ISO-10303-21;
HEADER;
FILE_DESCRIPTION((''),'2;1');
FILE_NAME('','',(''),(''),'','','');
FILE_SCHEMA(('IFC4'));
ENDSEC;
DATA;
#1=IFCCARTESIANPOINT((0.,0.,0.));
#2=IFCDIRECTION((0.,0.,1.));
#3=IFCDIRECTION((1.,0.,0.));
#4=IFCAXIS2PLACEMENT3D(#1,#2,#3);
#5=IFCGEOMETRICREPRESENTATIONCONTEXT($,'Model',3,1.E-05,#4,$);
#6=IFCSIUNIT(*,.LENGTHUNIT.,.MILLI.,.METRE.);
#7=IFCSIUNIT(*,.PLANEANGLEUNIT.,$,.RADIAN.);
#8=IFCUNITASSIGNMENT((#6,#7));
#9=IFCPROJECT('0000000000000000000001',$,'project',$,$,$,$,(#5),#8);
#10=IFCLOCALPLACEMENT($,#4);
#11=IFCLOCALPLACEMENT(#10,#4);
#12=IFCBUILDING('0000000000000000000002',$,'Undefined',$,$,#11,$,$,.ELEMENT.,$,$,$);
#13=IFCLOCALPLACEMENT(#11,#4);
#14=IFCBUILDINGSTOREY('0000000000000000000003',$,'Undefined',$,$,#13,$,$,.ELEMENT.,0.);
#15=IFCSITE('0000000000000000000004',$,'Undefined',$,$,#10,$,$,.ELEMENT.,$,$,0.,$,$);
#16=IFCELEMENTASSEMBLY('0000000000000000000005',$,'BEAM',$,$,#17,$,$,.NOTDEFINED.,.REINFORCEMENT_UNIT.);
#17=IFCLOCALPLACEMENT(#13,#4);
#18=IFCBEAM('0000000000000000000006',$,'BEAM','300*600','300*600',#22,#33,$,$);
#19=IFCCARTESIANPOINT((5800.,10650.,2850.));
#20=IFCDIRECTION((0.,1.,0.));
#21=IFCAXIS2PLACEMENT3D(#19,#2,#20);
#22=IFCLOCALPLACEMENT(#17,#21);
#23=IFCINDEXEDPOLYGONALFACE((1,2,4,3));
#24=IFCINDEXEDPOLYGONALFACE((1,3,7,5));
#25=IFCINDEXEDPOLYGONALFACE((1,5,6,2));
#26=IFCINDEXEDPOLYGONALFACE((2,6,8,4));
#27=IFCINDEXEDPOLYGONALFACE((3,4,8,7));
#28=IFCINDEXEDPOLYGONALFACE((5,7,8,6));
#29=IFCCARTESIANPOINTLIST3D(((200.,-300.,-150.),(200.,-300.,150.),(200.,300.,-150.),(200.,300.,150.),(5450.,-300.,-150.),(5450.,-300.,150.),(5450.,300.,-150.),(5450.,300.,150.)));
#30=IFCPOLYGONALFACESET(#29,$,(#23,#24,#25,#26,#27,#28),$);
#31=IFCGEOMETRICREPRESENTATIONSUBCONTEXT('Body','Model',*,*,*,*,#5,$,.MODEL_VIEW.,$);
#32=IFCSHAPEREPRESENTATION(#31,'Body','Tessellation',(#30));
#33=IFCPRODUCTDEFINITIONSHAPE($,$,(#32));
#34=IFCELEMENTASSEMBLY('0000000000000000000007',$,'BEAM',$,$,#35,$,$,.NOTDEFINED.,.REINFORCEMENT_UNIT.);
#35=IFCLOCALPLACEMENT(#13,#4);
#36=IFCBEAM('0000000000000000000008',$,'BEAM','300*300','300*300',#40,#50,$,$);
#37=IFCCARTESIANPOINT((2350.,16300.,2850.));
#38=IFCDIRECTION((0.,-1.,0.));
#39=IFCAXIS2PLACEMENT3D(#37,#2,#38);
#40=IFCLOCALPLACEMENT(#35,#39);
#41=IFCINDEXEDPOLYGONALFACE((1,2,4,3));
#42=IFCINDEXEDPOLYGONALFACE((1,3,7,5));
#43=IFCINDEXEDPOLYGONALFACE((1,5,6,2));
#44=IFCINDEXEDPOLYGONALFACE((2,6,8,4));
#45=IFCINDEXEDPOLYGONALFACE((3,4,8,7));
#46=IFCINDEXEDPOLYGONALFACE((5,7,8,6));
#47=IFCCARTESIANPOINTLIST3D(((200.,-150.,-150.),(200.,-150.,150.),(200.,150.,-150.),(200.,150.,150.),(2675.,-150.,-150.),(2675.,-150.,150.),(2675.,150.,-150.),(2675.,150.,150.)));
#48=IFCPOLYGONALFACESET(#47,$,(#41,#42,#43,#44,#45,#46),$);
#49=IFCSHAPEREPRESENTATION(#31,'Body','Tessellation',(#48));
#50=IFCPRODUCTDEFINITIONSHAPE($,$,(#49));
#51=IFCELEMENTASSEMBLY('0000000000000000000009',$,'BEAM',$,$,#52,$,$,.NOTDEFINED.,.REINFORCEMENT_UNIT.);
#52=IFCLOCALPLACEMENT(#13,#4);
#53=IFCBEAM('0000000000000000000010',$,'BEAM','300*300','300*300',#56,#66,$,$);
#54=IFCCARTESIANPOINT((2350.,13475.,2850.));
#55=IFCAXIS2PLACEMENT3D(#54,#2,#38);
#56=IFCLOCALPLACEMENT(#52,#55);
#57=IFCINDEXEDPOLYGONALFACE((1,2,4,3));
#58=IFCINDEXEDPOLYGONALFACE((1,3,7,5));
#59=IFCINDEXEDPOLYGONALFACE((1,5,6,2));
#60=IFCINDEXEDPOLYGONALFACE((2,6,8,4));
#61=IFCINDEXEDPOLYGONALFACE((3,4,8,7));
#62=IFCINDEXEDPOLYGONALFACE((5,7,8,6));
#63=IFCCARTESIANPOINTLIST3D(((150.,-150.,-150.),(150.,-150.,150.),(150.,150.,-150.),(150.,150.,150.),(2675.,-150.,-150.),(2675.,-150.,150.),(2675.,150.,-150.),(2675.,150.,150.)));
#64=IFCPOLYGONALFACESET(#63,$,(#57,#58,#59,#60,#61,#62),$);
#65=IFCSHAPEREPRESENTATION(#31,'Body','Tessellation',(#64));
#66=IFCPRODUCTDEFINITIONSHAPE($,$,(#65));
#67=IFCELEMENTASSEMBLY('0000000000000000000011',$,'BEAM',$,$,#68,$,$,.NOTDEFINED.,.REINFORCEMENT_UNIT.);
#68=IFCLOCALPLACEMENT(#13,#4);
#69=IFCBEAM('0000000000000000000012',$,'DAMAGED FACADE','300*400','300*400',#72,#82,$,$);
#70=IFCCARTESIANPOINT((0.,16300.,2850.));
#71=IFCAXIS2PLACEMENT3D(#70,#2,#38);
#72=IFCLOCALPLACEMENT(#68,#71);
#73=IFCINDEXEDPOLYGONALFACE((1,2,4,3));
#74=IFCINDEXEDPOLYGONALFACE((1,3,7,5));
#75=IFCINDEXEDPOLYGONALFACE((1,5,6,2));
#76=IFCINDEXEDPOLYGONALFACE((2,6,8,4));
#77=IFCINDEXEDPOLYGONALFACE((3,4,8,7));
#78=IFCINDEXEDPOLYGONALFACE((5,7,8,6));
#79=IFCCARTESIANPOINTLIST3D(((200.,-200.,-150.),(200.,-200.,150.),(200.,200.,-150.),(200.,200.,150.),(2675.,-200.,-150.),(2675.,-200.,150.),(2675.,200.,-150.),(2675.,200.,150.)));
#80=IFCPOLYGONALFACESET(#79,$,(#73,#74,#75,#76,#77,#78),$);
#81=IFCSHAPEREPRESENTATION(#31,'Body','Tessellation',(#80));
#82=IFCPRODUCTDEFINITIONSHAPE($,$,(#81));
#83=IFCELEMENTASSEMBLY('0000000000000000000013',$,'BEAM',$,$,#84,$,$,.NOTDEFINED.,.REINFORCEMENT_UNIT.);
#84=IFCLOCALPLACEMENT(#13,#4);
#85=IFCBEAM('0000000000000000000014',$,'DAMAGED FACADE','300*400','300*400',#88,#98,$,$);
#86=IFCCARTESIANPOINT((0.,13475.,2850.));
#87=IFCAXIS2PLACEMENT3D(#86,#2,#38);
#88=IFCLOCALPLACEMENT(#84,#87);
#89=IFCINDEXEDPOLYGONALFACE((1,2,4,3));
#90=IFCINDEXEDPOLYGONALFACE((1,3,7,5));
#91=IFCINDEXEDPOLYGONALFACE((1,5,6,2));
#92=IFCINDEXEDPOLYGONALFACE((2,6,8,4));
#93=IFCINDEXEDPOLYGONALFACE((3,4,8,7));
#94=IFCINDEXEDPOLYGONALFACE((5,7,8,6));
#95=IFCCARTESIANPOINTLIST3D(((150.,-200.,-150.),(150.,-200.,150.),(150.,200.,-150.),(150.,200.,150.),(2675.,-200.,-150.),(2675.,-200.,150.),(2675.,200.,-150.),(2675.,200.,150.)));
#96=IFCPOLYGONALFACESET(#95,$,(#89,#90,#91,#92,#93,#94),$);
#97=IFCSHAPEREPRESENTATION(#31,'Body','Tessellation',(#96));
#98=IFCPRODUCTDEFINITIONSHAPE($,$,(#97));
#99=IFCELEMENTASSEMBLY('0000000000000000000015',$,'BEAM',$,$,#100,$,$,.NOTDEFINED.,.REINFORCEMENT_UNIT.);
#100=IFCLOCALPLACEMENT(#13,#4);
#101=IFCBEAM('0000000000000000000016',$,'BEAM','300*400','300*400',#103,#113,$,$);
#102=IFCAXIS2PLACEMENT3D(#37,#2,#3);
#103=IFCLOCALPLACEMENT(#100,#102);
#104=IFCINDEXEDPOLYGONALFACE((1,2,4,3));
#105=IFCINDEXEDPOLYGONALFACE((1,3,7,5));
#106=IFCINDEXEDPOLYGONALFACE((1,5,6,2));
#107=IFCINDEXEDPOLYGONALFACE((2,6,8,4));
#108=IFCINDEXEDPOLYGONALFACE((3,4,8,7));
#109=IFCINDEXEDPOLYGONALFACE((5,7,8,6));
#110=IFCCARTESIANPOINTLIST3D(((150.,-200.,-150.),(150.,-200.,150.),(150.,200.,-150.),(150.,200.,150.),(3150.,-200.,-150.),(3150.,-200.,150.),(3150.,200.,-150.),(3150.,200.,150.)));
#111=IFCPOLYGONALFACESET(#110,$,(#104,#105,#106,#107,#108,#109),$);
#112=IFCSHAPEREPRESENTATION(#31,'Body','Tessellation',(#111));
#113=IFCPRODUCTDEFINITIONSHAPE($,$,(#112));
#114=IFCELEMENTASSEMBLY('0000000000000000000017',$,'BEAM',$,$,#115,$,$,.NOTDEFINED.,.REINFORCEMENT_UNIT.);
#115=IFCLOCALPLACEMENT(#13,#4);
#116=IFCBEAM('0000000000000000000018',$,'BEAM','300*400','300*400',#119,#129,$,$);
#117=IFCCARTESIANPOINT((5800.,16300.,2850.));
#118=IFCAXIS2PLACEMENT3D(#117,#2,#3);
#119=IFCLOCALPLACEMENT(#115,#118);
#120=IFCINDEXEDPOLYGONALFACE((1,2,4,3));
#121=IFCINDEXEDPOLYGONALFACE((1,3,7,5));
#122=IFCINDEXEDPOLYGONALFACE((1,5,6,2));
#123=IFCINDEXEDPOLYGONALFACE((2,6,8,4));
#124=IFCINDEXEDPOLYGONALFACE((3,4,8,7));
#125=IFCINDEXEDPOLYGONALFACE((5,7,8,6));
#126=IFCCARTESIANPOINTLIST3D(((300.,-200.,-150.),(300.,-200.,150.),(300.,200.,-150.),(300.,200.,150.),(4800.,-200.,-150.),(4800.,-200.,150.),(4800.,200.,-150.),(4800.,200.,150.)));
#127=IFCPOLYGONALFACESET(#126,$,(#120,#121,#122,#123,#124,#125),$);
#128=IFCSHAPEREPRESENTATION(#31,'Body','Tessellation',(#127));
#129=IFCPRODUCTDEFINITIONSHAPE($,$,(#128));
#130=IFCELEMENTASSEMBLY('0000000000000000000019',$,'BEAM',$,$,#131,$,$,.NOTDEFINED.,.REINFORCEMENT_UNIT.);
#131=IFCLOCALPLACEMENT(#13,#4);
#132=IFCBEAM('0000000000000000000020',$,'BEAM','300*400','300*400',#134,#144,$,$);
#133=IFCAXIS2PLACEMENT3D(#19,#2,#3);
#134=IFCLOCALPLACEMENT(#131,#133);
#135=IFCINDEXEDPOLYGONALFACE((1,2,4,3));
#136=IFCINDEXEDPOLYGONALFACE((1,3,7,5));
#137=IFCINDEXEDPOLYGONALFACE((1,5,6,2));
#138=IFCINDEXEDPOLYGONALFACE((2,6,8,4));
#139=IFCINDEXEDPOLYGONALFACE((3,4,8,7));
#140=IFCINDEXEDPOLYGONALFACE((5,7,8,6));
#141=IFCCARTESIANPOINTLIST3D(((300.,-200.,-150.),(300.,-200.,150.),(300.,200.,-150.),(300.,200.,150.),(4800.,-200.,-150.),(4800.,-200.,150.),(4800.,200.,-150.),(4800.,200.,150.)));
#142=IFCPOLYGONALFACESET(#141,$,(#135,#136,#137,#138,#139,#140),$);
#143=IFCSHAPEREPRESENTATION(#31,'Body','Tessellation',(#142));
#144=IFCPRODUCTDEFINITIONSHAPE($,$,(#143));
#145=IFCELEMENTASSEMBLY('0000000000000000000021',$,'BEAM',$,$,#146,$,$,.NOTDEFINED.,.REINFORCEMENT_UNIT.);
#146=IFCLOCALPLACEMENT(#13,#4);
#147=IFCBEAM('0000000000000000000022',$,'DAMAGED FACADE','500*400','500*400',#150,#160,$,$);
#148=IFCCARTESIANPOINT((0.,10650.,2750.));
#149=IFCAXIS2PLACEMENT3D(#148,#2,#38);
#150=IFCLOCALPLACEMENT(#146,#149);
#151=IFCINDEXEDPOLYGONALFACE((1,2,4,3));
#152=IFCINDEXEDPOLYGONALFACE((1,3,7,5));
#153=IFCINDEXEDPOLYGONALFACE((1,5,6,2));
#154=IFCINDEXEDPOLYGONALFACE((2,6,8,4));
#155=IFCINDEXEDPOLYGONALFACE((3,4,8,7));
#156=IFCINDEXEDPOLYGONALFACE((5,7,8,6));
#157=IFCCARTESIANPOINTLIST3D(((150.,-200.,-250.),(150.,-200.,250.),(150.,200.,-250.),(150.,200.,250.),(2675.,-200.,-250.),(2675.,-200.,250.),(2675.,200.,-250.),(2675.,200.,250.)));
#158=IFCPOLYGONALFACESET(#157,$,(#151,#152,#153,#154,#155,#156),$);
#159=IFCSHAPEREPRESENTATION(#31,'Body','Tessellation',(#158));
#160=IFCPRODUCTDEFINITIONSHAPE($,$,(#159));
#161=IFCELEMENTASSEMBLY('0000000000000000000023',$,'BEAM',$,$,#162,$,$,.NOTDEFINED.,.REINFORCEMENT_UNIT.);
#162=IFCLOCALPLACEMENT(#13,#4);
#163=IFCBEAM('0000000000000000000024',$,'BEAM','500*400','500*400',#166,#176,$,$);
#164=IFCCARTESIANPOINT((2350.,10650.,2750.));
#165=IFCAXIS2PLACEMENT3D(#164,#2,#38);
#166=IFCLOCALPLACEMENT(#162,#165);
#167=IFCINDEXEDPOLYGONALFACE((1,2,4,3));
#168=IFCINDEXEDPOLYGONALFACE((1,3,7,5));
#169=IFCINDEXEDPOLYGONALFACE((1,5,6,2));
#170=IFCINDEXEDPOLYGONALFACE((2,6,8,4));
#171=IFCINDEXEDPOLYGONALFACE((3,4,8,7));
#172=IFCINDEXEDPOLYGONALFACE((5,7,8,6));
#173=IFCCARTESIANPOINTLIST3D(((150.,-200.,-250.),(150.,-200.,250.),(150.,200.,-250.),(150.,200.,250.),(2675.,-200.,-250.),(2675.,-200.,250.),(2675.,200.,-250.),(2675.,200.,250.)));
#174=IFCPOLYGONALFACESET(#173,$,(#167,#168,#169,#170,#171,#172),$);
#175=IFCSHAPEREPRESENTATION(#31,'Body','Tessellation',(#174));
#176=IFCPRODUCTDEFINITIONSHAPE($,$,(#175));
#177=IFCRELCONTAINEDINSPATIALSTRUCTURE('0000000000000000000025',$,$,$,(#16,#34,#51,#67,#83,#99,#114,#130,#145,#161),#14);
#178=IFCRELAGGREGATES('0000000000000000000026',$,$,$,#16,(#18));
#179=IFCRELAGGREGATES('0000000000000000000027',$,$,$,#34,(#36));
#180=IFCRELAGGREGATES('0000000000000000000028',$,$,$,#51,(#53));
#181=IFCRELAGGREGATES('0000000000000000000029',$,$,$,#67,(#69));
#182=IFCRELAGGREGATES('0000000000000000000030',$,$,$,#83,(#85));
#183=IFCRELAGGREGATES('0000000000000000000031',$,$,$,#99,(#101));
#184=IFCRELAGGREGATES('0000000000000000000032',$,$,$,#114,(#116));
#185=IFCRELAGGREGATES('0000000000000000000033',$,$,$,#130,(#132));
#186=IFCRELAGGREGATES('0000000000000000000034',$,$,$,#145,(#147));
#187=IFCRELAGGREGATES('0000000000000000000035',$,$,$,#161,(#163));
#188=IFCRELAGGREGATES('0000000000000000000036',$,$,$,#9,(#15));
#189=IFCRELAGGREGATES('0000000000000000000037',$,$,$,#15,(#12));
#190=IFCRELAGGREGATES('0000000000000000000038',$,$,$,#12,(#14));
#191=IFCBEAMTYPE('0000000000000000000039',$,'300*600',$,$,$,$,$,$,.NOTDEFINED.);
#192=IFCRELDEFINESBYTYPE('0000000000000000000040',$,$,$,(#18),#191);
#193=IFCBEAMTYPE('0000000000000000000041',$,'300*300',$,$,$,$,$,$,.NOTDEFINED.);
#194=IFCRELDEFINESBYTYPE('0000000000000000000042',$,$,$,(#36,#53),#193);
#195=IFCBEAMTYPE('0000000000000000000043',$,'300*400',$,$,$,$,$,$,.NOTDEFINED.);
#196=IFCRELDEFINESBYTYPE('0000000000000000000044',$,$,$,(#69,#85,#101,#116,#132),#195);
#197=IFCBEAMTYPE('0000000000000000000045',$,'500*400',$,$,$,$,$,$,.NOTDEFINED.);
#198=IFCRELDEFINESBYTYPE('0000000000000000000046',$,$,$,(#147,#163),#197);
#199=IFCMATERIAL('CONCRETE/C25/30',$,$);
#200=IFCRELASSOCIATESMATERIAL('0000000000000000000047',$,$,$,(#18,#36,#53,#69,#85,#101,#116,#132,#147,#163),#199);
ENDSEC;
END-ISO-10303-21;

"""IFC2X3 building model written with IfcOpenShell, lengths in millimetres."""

from ifc_helpers import new_model, si_unit, frame, origin_with_axes, origin_2d_with_axis, place, context, subcontext, project, spatial, rectangle, extrude, material, type_object, element, aggregate, save


model = new_model("IFC2X3")

# Units and contexts
model_context = context("Model", 3, precision=1e-05, world=origin_with_axes())
body_context = subcontext(model_context, "Body", "Model", "MODEL_VIEW")
ifc_project = project(units=[si_unit("LENGTHUNIT", "METRE", prefix="MILLI"), si_unit("PLANEANGLEUNIT", "RADIAN")], contexts=[model_context])

# Site, building, storey
site_placement = place(None, origin_with_axes())
site = spatial("IfcSite", under=ifc_project, at=site_placement, Name="Undefined", CompositionType="ELEMENT", RefElevation=0.0)
building_placement = place(site_placement, origin_with_axes())
building = spatial("IfcBuilding", under=site, at=building_placement, Name="Undefined", CompositionType="ELEMENT")
storey_placement = place(building_placement, origin_with_axes())
storey = spatial("IfcBuildingStorey", under=building, at=storey_placement, Name="Undefined", CompositionType="ELEMENT", Elevation=0.0)

# Shared definitions
ifc_material = material(Name="CONCRETE/C25/30")

# Element assemblies, beams
assembly_1_placement = place(storey_placement, origin_with_axes())
assembly_1 = element("IfcElementAssembly", 1, at=assembly_1_placement, inside=storey, Name="BEAM", AssemblyPlace="NOTDEFINED", PredefinedType="REINFORCEMENT_UNIT")
beam_type_1 = type_object("IfcBeamType", Name="300*600", PredefinedType="NOTDEFINED")
beam_1_placement = place(assembly_1_placement, frame((5800.0, 10650.0, 2850.0), z_axis=(0.0, 0.0, 1.0), x_axis=(0.0, 1.0, 0.0)))
beam_1 = element("IfcBeam", 2, at=beam_1_placement, type_object=beam_type_1, material=ifc_material, Name="BEAM", Description="300*600", ObjectType="300*600", context=body_context, shape_type="SweptSolid", body=[
    extrude(rectangle(XDim=600.0, YDim=300.0, at=origin_2d_with_axis()), frame((5450.0, 0.0, 0.0), z_axis=(-1.0, 0.0, 0.0), x_axis=(0.0, -1.0, 0.0)), (0.0, 0.0, 1.0), 5250.0),
])
aggregate(assembly_1, [beam_1])
assembly_2_placement = place(storey_placement, origin_with_axes())
assembly_2 = element("IfcElementAssembly", 3, at=assembly_2_placement, inside=storey, Name="BEAM", AssemblyPlace="NOTDEFINED", PredefinedType="REINFORCEMENT_UNIT")
beam_type_2 = type_object("IfcBeamType", Name="300*300", PredefinedType="NOTDEFINED")
beam_2_placement = place(assembly_2_placement, frame((2350.0, 16300.0, 2850.0), z_axis=(0.0, 0.0, 1.0), x_axis=(0.0, -1.0, 0.0)))
beam_2 = element("IfcBeam", 4, at=beam_2_placement, type_object=beam_type_2, material=ifc_material, Name="BEAM", Description="300*300", ObjectType="300*300", context=body_context, shape_type="SweptSolid", body=[
    extrude(rectangle(XDim=300.0, YDim=300.0, at=origin_2d_with_axis()), frame((2675.0, 0.0, 0.0), z_axis=(-1.0, 0.0, 0.0), x_axis=(0.0, -1.0, 0.0)), (0.0, 0.0, 1.0), 2475.0),
])
aggregate(assembly_2, [beam_2])
assembly_3_placement = place(storey_placement, origin_with_axes())
assembly_3 = element("IfcElementAssembly", 5, at=assembly_3_placement, inside=storey, Name="BEAM", AssemblyPlace="NOTDEFINED", PredefinedType="REINFORCEMENT_UNIT")
beam_3_placement = place(assembly_3_placement, frame((2350.0, 13475.0, 2850.0), z_axis=(0.0, 0.0, 1.0), x_axis=(0.0, -1.0, 0.0)))
beam_3 = element("IfcBeam", 6, at=beam_3_placement, type_object=beam_type_2, material=ifc_material, Name="BEAM", Description="300*300", ObjectType="300*300", context=body_context, shape_type="SweptSolid", body=[
    extrude(rectangle(XDim=300.0, YDim=300.0, at=origin_2d_with_axis()), frame((2675.0, 0.0, 0.0), z_axis=(-1.0, 0.0, 0.0), x_axis=(0.0, -1.0, 0.0)), (0.0, 0.0, 1.0), 2525.0),
])
aggregate(assembly_3, [beam_3])
assembly_4_placement = place(storey_placement, origin_with_axes())
assembly_4 = element("IfcElementAssembly", 7, at=assembly_4_placement, inside=storey, Name="BEAM", AssemblyPlace="NOTDEFINED", PredefinedType="REINFORCEMENT_UNIT")
beam_type_3 = type_object("IfcBeamType", Name="300*400", PredefinedType="NOTDEFINED")
beam_4_placement = place(assembly_4_placement, frame((0.0, 16300.0, 2850.0), z_axis=(0.0, 0.0, 1.0), x_axis=(0.0, -1.0, 0.0)))
beam_4 = element("IfcBeam", 8, at=beam_4_placement, type_object=beam_type_3, material=ifc_material, Name="DAMAGED FACADE", Description="300*400", ObjectType="300*400", context=body_context, shape_type="SweptSolid", body=[
    extrude(rectangle(XDim=400.0, YDim=300.0, at=origin_2d_with_axis()), frame((2675.0, 0.0, 0.0), z_axis=(-1.0, 0.0, 0.0), x_axis=(0.0, -1.0, 0.0)), (0.0, 0.0, 1.0), 2475.0),
])
aggregate(assembly_4, [beam_4])
assembly_5_placement = place(storey_placement, origin_with_axes())
assembly_5 = element("IfcElementAssembly", 9, at=assembly_5_placement, inside=storey, Name="BEAM", AssemblyPlace="NOTDEFINED", PredefinedType="REINFORCEMENT_UNIT")
beam_5_placement = place(assembly_5_placement, frame((0.0, 13475.0, 2850.0), z_axis=(0.0, 0.0, 1.0), x_axis=(0.0, -1.0, 0.0)))
beam_5 = element("IfcBeam", 10, at=beam_5_placement, type_object=beam_type_3, material=ifc_material, Name="DAMAGED FACADE", Description="300*400", ObjectType="300*400", context=body_context, shape_type="SweptSolid", body=[
    extrude(rectangle(XDim=400.0, YDim=300.0, at=origin_2d_with_axis()), frame((2675.0, 0.0, 0.0), z_axis=(-1.0, 0.0, 0.0), x_axis=(0.0, -1.0, 0.0)), (0.0, 0.0, 1.0), 2525.0),
])
aggregate(assembly_5, [beam_5])
assembly_6_placement = place(storey_placement, origin_with_axes())
assembly_6 = element("IfcElementAssembly", 11, at=assembly_6_placement, inside=storey, Name="BEAM", AssemblyPlace="NOTDEFINED", PredefinedType="REINFORCEMENT_UNIT")
beam_6_placement = place(assembly_6_placement, frame((2350.0, 16300.0, 2850.0), z_axis=(0.0, 0.0, 1.0), x_axis=(1.0, 0.0, 0.0)))
beam_6 = element("IfcBeam", 12, at=beam_6_placement, type_object=beam_type_3, material=ifc_material, Name="BEAM", Description="300*400", ObjectType="300*400", context=body_context, shape_type="SweptSolid", body=[
    extrude(rectangle(XDim=400.0, YDim=300.0, at=origin_2d_with_axis()), frame((3150.0, 0.0, 0.0), z_axis=(-1.0, 0.0, 0.0), x_axis=(0.0, -1.0, 0.0)), (0.0, 0.0, 1.0), 3000.0),
])
aggregate(assembly_6, [beam_6])
assembly_7_placement = place(storey_placement, origin_with_axes())
assembly_7 = element("IfcElementAssembly", 13, at=assembly_7_placement, inside=storey, Name="BEAM", AssemblyPlace="NOTDEFINED", PredefinedType="REINFORCEMENT_UNIT")
beam_7_placement = place(assembly_7_placement, frame((5800.0, 16300.0, 2850.0), z_axis=(0.0, 0.0, 1.0), x_axis=(1.0, 0.0, 0.0)))
beam_7 = element("IfcBeam", 14, at=beam_7_placement, type_object=beam_type_3, material=ifc_material, Name="BEAM", Description="300*400", ObjectType="300*400", context=body_context, shape_type="SweptSolid", body=[
    extrude(rectangle(XDim=400.0, YDim=300.0, at=origin_2d_with_axis()), frame((4800.0, 0.0, 0.0), z_axis=(-1.0, 0.0, 0.0), x_axis=(0.0, -1.0, 0.0)), (0.0, 0.0, 1.0), 4500.0),
])
aggregate(assembly_7, [beam_7])
assembly_8_placement = place(storey_placement, origin_with_axes())
assembly_8 = element("IfcElementAssembly", 15, at=assembly_8_placement, inside=storey, Name="BEAM", AssemblyPlace="NOTDEFINED", PredefinedType="REINFORCEMENT_UNIT")
beam_8_placement = place(assembly_8_placement, frame((5800.0, 10650.0, 2850.0), z_axis=(0.0, 0.0, 1.0), x_axis=(1.0, 0.0, 0.0)))
beam_8 = element("IfcBeam", 16, at=beam_8_placement, type_object=beam_type_3, material=ifc_material, Name="BEAM", Description="300*400", ObjectType="300*400", context=body_context, shape_type="SweptSolid", body=[
    extrude(rectangle(XDim=400.0, YDim=300.0, at=origin_2d_with_axis()), frame((4800.0, 0.0, 0.0), z_axis=(-1.0, 0.0, 0.0), x_axis=(0.0, -1.0, 0.0)), (0.0, 0.0, 1.0), 4500.0),
])
aggregate(assembly_8, [beam_8])
assembly_9_placement = place(storey_placement, origin_with_axes())
assembly_9 = element("IfcElementAssembly", 17, at=assembly_9_placement, inside=storey, Name="BEAM", AssemblyPlace="NOTDEFINED", PredefinedType="REINFORCEMENT_UNIT")
beam_type_4 = type_object("IfcBeamType", Name="500*400", PredefinedType="NOTDEFINED")
beam_9_placement = place(assembly_9_placement, frame((0.0, 10650.0, 2750.0), z_axis=(0.0, 0.0, 1.0), x_axis=(0.0, -1.0, 0.0)))
beam_9 = element("IfcBeam", 18, at=beam_9_placement, type_object=beam_type_4, material=ifc_material, Name="DAMAGED FACADE", Description="500*400", ObjectType="500*400", context=body_context, shape_type="SweptSolid", body=[
    extrude(rectangle(XDim=400.0, YDim=500.0, at=origin_2d_with_axis()), frame((2675.0, 0.0, 0.0), z_axis=(-1.0, 0.0, 0.0), x_axis=(0.0, -1.0, 0.0)), (0.0, 0.0, 1.0), 2525.0),
])
aggregate(assembly_9, [beam_9])
assembly_10_placement = place(storey_placement, origin_with_axes())
assembly_10 = element("IfcElementAssembly", 19, at=assembly_10_placement, inside=storey, Name="BEAM", AssemblyPlace="NOTDEFINED", PredefinedType="REINFORCEMENT_UNIT")
beam_10_placement = place(assembly_10_placement, frame((2350.0, 10650.0, 2750.0), z_axis=(0.0, 0.0, 1.0), x_axis=(0.0, -1.0, 0.0)))
beam_10 = element("IfcBeam", 20, at=beam_10_placement, type_object=beam_type_4, material=ifc_material, Name="BEAM", Description="500*400", ObjectType="500*400", context=body_context, shape_type="SweptSolid", body=[
    extrude(rectangle(XDim=400.0, YDim=500.0, at=origin_2d_with_axis()), frame((2675.0, 0.0, 0.0), z_axis=(-1.0, 0.0, 0.0), x_axis=(0.0, -1.0, 0.0)), (0.0, 0.0, 1.0), 2525.0),
])
aggregate(assembly_10, [beam_10])

save(model, "model.ifc")
